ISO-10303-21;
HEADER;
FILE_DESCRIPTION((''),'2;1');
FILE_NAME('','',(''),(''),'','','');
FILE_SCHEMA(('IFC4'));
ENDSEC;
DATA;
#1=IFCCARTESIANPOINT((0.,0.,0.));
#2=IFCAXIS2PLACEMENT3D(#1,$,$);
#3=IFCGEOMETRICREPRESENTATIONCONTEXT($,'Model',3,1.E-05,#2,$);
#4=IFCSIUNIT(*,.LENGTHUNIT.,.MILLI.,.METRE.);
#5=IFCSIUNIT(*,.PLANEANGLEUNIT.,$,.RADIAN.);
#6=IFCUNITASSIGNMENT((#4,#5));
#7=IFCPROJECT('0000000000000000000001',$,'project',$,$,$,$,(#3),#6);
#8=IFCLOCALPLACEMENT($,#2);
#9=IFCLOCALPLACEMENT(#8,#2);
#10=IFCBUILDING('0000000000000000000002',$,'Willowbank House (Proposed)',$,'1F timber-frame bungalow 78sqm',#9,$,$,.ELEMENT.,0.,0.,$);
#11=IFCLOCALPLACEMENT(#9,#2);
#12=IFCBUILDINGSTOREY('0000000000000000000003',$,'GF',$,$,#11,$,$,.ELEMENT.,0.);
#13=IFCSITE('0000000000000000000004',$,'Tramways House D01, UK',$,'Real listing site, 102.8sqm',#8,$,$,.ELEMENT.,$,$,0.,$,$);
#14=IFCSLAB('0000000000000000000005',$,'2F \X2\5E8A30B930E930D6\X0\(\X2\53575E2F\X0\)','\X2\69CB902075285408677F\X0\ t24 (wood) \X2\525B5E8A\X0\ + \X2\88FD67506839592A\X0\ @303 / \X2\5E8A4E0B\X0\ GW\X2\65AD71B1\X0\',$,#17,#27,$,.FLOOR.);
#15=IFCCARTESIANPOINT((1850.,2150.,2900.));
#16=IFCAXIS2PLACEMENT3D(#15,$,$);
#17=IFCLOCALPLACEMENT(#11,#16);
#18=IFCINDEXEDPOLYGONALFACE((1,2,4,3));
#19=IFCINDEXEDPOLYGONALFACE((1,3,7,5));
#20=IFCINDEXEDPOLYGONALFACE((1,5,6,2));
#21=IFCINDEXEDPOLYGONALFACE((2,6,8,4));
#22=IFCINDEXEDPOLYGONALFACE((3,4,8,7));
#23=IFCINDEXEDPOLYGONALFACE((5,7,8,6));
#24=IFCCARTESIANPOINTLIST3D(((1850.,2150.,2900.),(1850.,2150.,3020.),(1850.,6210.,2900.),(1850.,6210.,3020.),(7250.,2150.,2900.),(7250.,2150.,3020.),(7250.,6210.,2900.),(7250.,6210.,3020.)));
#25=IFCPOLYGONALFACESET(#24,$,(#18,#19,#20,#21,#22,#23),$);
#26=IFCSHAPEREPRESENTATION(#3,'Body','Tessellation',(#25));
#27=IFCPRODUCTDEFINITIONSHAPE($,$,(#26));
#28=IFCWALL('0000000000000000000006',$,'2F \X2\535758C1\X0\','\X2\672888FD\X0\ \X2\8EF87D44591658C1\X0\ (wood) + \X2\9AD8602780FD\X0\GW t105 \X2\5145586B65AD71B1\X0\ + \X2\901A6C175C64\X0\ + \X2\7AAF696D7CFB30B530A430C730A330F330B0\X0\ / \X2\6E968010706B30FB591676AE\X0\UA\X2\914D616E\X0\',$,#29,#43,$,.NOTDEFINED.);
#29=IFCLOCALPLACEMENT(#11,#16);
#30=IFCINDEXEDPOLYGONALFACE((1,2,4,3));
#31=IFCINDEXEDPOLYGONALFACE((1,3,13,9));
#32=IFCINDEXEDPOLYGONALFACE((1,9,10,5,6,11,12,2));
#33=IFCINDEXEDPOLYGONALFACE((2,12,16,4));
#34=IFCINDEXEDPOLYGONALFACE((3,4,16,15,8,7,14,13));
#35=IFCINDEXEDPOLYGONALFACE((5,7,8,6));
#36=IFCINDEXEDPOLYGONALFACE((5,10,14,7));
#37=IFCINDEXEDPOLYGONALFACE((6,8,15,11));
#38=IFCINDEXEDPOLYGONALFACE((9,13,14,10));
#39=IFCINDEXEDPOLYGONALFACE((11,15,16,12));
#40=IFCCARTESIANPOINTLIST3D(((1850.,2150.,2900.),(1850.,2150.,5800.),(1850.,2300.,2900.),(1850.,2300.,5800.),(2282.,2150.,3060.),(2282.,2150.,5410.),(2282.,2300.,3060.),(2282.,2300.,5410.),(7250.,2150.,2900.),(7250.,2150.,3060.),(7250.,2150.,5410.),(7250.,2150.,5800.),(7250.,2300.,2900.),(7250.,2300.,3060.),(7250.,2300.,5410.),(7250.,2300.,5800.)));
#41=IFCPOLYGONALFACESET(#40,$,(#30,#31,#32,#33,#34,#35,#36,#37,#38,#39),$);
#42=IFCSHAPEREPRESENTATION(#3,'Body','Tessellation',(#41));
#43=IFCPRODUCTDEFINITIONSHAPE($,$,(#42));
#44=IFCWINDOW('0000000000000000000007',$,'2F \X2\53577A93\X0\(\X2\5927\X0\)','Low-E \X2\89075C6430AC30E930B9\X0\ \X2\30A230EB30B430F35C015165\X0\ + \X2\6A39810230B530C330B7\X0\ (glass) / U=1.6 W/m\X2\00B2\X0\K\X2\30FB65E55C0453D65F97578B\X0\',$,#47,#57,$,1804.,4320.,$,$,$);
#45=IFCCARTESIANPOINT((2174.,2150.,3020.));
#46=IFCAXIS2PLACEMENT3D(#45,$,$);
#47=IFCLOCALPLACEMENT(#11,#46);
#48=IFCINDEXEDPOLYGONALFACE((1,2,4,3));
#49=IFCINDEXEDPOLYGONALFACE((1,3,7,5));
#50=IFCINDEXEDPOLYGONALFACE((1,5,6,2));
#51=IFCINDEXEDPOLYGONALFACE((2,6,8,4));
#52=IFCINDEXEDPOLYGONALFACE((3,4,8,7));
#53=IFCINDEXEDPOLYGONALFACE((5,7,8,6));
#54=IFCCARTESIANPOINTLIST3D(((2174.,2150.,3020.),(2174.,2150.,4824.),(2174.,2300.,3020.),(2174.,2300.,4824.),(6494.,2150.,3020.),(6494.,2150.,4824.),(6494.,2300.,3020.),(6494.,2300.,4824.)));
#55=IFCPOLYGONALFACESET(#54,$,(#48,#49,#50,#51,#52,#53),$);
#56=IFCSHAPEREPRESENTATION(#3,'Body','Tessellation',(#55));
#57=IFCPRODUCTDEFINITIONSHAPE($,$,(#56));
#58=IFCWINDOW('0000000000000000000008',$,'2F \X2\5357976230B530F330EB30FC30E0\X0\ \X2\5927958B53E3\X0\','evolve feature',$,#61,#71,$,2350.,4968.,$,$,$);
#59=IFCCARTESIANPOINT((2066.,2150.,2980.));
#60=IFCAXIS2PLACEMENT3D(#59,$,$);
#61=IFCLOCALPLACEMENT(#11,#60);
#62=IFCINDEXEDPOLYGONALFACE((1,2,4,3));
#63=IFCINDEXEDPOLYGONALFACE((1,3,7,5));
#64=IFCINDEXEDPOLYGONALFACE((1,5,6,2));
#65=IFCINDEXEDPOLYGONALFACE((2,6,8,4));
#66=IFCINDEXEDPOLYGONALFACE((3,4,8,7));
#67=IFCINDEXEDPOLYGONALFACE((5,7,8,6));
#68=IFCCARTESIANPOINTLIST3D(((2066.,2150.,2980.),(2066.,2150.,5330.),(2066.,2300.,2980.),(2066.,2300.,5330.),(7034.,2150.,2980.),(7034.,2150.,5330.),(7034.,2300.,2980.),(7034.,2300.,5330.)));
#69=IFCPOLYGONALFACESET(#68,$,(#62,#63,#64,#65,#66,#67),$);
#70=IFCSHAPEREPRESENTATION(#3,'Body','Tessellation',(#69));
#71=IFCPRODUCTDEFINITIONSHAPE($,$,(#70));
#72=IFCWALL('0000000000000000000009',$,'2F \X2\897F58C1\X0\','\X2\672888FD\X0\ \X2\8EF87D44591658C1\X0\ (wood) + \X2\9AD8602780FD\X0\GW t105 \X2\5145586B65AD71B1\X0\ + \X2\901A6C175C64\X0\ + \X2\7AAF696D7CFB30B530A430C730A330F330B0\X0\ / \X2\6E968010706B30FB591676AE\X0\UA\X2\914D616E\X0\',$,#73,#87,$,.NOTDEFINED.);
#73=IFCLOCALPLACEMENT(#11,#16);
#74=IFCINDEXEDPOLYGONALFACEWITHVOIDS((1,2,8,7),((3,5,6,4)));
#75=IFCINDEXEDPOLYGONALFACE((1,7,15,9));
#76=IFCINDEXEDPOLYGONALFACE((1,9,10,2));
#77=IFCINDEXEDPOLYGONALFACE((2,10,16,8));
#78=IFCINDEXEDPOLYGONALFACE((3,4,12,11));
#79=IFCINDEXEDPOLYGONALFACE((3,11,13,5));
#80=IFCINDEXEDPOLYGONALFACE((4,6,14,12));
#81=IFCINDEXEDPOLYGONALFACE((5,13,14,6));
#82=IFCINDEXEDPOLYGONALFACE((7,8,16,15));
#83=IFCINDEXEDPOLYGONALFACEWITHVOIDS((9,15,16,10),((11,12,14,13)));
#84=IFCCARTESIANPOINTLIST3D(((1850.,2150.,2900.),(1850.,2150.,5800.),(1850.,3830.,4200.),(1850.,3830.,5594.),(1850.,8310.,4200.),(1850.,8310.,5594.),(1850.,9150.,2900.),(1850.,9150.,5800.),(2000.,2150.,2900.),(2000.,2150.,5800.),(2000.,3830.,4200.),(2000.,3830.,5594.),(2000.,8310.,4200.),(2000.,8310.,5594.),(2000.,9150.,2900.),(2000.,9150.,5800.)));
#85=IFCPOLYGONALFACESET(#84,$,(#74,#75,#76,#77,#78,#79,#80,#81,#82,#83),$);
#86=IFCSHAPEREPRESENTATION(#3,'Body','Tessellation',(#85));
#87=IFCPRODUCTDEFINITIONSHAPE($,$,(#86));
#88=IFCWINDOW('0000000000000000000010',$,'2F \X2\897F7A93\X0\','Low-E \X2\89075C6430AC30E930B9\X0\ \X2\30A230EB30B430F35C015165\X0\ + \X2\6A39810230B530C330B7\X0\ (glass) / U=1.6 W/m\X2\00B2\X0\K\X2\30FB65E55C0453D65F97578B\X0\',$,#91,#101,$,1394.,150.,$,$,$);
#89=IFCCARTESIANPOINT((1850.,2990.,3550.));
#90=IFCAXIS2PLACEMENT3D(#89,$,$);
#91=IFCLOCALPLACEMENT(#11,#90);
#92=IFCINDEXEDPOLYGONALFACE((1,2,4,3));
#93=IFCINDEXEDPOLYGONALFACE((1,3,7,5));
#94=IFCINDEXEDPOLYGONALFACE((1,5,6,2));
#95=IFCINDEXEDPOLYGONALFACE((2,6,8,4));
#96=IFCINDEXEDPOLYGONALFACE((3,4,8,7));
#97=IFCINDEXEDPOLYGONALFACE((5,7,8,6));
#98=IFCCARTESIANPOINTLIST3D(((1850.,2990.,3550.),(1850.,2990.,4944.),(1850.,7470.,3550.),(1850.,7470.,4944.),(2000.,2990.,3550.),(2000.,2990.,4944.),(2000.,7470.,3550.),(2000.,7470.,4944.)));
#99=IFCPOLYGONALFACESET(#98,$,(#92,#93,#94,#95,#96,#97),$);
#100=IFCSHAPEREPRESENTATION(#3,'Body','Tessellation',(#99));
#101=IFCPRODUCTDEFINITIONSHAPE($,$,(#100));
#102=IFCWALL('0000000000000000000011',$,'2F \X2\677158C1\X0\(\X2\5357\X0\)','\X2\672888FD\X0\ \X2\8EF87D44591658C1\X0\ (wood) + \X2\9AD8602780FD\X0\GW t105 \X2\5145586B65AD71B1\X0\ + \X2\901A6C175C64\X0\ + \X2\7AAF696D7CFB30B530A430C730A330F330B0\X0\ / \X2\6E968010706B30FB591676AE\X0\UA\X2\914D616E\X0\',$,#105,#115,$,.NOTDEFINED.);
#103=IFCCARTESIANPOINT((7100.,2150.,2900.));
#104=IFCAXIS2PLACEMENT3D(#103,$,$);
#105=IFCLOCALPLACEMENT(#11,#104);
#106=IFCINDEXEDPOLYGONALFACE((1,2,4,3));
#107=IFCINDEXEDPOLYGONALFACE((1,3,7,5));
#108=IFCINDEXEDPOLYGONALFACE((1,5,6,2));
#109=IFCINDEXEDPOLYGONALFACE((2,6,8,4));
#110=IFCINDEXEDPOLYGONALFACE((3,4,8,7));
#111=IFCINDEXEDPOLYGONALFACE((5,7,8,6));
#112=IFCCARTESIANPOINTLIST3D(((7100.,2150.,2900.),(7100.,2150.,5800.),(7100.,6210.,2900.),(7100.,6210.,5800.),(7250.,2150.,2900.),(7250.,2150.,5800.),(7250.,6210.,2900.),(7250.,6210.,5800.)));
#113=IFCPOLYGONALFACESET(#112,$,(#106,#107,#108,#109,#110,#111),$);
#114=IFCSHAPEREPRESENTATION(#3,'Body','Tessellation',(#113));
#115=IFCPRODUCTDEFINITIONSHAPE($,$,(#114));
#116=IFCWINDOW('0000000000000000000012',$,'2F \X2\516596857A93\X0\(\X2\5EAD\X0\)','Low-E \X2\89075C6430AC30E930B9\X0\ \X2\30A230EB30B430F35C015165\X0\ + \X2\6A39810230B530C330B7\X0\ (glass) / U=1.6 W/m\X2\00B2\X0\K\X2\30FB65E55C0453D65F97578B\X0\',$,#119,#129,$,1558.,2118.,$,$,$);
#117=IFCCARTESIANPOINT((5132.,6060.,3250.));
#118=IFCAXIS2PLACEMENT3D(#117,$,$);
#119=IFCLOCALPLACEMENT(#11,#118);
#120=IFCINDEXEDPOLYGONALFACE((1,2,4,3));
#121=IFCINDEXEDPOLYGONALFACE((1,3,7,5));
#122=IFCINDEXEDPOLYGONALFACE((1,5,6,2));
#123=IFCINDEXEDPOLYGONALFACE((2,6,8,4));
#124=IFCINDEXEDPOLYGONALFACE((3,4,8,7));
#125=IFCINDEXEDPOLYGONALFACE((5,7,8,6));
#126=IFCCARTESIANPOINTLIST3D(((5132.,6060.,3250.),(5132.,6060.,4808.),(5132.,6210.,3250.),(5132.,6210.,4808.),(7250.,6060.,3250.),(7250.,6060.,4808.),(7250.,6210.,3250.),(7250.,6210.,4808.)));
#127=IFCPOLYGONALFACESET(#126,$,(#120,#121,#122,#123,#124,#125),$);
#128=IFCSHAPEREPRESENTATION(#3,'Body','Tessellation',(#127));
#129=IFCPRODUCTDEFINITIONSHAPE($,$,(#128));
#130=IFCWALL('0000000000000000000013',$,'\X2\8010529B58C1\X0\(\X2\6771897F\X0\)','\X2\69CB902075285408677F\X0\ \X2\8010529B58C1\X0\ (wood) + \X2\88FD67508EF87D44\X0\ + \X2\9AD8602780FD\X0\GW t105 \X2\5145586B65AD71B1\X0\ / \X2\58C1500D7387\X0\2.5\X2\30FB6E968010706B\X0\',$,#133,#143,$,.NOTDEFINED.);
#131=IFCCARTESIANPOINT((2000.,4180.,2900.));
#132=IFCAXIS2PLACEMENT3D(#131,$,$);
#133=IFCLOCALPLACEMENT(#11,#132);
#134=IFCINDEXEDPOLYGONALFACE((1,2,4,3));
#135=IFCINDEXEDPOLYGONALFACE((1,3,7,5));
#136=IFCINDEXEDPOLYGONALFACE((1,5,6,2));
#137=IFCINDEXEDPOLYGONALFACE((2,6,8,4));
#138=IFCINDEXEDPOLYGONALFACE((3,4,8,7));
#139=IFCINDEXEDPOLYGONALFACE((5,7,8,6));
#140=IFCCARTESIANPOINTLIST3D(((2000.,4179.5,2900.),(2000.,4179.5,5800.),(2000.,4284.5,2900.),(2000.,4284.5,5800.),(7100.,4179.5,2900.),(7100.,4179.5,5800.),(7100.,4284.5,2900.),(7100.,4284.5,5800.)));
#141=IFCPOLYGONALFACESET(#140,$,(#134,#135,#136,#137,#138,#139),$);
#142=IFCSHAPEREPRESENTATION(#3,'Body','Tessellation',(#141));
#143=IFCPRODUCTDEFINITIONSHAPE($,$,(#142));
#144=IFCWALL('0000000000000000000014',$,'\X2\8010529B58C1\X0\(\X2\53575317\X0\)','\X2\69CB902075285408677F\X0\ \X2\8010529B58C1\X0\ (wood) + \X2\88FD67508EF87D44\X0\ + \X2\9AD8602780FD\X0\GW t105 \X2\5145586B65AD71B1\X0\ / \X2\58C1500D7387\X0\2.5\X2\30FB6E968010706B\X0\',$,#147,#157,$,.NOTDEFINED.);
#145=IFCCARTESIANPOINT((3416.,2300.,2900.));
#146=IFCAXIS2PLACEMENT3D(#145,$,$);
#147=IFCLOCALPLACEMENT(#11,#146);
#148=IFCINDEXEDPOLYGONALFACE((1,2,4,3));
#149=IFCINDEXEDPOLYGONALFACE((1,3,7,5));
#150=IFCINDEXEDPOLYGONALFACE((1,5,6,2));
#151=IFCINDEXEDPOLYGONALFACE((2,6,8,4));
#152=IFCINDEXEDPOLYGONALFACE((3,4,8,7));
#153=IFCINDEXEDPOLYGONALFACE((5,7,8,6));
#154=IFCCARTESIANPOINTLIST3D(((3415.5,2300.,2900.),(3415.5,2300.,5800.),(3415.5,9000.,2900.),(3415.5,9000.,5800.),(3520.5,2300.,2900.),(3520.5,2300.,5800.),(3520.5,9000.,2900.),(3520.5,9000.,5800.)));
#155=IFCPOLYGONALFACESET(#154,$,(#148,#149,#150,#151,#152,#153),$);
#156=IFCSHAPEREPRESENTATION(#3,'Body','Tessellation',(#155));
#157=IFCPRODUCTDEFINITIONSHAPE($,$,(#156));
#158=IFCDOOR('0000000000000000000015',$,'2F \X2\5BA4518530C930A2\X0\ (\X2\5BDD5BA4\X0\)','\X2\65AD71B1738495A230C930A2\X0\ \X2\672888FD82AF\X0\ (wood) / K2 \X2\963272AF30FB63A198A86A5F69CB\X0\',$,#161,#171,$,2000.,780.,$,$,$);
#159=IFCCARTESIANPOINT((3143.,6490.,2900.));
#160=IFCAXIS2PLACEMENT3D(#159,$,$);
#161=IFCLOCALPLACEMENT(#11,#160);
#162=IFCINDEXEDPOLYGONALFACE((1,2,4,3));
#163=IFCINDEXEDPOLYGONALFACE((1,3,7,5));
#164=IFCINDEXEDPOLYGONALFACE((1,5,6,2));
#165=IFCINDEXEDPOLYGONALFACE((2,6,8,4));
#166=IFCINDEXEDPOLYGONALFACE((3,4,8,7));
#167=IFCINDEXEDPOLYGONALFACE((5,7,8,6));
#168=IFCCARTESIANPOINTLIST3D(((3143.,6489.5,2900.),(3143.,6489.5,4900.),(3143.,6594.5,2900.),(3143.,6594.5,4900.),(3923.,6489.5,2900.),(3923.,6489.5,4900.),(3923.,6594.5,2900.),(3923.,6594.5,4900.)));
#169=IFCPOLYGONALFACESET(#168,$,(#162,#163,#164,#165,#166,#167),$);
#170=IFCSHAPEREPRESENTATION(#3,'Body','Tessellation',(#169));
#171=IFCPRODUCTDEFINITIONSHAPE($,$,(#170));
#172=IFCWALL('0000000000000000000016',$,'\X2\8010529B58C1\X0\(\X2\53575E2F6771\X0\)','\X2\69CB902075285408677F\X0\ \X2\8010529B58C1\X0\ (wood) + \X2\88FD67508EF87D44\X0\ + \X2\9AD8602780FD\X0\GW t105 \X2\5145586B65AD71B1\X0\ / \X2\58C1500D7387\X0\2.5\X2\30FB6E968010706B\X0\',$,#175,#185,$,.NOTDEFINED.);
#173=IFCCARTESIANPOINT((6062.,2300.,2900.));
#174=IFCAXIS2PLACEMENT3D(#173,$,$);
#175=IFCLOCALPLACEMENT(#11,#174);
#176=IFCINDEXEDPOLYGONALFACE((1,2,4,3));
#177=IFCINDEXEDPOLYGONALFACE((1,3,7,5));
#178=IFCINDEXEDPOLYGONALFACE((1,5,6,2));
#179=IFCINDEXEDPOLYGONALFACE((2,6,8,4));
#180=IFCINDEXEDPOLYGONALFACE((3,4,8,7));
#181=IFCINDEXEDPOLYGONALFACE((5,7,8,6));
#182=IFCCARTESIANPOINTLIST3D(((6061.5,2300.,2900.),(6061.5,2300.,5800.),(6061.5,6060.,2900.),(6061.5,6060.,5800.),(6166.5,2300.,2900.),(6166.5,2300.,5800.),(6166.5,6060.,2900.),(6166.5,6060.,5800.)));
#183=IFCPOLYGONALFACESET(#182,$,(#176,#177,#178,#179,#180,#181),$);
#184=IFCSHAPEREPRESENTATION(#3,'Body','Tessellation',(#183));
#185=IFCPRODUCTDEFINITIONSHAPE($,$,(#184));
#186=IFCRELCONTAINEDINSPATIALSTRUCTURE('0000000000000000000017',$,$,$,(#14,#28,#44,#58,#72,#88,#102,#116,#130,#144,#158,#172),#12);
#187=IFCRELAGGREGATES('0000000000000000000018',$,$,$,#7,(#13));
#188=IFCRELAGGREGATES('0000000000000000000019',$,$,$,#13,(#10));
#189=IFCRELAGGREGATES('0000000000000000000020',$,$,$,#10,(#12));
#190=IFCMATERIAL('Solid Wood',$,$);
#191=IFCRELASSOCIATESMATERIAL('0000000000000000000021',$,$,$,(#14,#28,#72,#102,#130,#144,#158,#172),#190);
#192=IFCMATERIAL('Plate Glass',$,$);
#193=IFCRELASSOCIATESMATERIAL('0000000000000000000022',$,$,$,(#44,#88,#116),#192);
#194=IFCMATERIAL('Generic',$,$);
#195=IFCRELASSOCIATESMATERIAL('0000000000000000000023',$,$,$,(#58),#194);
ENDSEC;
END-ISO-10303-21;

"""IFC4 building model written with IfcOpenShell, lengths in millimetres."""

from ifc_helpers import new_model, si_unit, frame, frame_2d, origin, place, context, project, spatial, rectangle, extrude, material, element, fill, save


model = new_model("IFC4")

# Units and contexts
model_context = context("Model", 3, precision=1e-05, world=origin())
ifc_project = project(units=[si_unit("LENGTHUNIT", "METRE", prefix="MILLI"), si_unit("PLANEANGLEUNIT", "RADIAN")], contexts=[model_context])

# Site, building, storey
site_placement = place(None, origin())
site = spatial("IfcSite", under=ifc_project, at=site_placement, Name="Tramways House D01, UK", ObjectType="Real listing site, 102.8sqm", CompositionType="ELEMENT", RefElevation=0.0)
building_placement = place(site_placement, origin())
building = spatial("IfcBuilding", under=site, at=building_placement, Name="Willowbank House (Proposed)", ObjectType="1F timber-frame bungalow 78sqm", CompositionType="ELEMENT", ElevationOfRefHeight=0.0, ElevationOfTerrain=0.0)
storey_placement = place(building_placement, origin())
storey = spatial("IfcBuildingStorey", under=building, at=storey_placement, Name="GF", CompositionType="ELEMENT", Elevation=0.0)

# Slab
ifc_material_1 = material(Name="Solid Wood")
slab_placement = place(storey_placement, frame((1850.0, 2150.0, 2900.0)))
element("IfcSlab", 1, at=slab_placement, inside=storey, material=ifc_material_1, Name="2F 床スラブ(南帯)", Description="構造用合板 t24 (wood) 剛床 + 製材根太 @303 / 床下 GW断熱", PredefinedType="FLOOR", context=model_context, shape_type="SweptSolid", body=[
    extrude(rectangle(XDim=5400.0, YDim=4060.0, at=frame_2d((2700.0, 2030.0))), frame((1850.0, 2150.0, 2900.0)), (0.0, 0.0, 1.0), 120.0),
])

# Wall, openings, windows
wall_1_placement = place(storey_placement, frame((1850.0, 2150.0, 2900.0)))
wall_1 = element("IfcWall", 2, at=wall_1_placement, inside=storey, material=ifc_material_1, Name="2F 南壁", Description="木製 軸組外壁 (wood) + 高性能GW t105 充填断熱 + 通気層 + 窯業系サイディング / 準耐火・外皮UA配慮", PredefinedType="NOTDEFINED", context=model_context, shape_type="SweptSolid", body=[
    extrude(rectangle(XDim=5400.0, YDim=150.0, at=frame_2d((2700.0, 75.0))), frame((1850.0, 2150.0, 2900.0)), (0.0, 0.0, 1.0), 2900.0),
])
opening_1_placement = place(storey_placement, frame((2174.0, 2150.0, 3020.0)))
opening_1 = element("IfcOpeningElement", 3, at=opening_1_placement, cuts=wall_1, PredefinedType="NOTDEFINED", context=model_context, shape_type="SweptSolid", body=[
    extrude(rectangle(XDim=4320.0, YDim=150.0, at=frame_2d((2160.0, 75.0))), frame((2174.0, 2150.0, 3020.0)), (0.0, 0.0, 1.0), 1804.0),
])
opening_2_placement = place(storey_placement, frame((2066.0, 2150.0, 2980.0)))
opening_2 = element("IfcOpeningElement", 4, at=opening_2_placement, cuts=wall_1, PredefinedType="NOTDEFINED", context=model_context, shape_type="SweptSolid", body=[
    extrude(rectangle(XDim=4968.0, YDim=150.0, at=frame_2d((2484.0, 75.0))), frame((2066.0, 2150.0, 2980.0)), (0.0, 0.0, 1.0), 2350.0),
])
ifc_material_2 = material(Name="Plate Glass")
window_1_placement = place(storey_placement, frame((2174.0, 2150.0, 3020.0)))
window_1 = element("IfcWindow", 5, at=window_1_placement, inside=storey, material=ifc_material_2, Name="2F 南窓(大)", Description="Low-E 複層ガラス アルゴン封入 + 樹脂サッシ (glass) / U=1.6 W/m²K・日射取得型", OverallHeight=1804.0, OverallWidth=4320.0, context=model_context, shape_type="SweptSolid", body=[
    extrude(rectangle(XDim=4320.0, YDim=150.0, at=frame_2d((2160.0, 75.0))), frame((2174.0, 2150.0, 3020.0)), (0.0, 0.0, 1.0), 1804.0),
])
fill(opening_1, window_1)
ifc_material_3 = material(Name="Generic")
window_2_placement = place(storey_placement, frame((2066.0, 2150.0, 2980.0)))
window_2 = element("IfcWindow", 6, at=window_2_placement, inside=storey, material=ifc_material_3, Name="2F 南面サンルーム 大開口", Description="evolve feature", OverallHeight=2350.0, OverallWidth=4968.0, context=model_context, shape_type="SweptSolid", body=[
    extrude(rectangle(XDim=4968.0, YDim=150.0, at=frame_2d((2484.0, 75.0))), frame((2066.0, 2150.0, 2980.0)), (0.0, 0.0, 1.0), 2350.0),
])
fill(opening_2, window_2)

# Walls, openings, windows
wall_2_placement = place(storey_placement, frame((1850.0, 2150.0, 2900.0)))
wall_2 = element("IfcWall", 7, at=wall_2_placement, inside=storey, material=ifc_material_1, Name="2F 西壁", Description="木製 軸組外壁 (wood) + 高性能GW t105 充填断熱 + 通気層 + 窯業系サイディング / 準耐火・外皮UA配慮", PredefinedType="NOTDEFINED", context=model_context, shape_type="SweptSolid", body=[
    extrude(rectangle(XDim=150.0, YDim=7000.0, at=frame_2d((75.0, 3500.0))), frame((1850.0, 2150.0, 2900.0)), (0.0, 0.0, 1.0), 2900.0),
])
opening_3_placement = place(storey_placement, frame((1850.0, 2990.0, 3550.0)))
opening_3 = element("IfcOpeningElement", 8, at=opening_3_placement, cuts=wall_2, PredefinedType="NOTDEFINED", context=model_context, shape_type="SweptSolid", body=[
    extrude(rectangle(XDim=150.0, YDim=4480.0, at=frame_2d((75.0, 2240.0))), frame((1850.0, 2990.0, 3550.0)), (0.0, 0.0, 1.0), 1394.0),
])
window_3_placement = place(storey_placement, frame((1850.0, 2990.0, 3550.0)))
window_3 = element("IfcWindow", 9, at=window_3_placement, inside=storey, material=ifc_material_2, Name="2F 西窓", Description="Low-E 複層ガラス アルゴン封入 + 樹脂サッシ (glass) / U=1.6 W/m²K・日射取得型", OverallHeight=1394.0, OverallWidth=150.0, context=model_context, shape_type="SweptSolid", body=[
    extrude(rectangle(XDim=150.0, YDim=4480.0, at=frame_2d((75.0, 2240.0))), frame((1850.0, 2990.0, 3550.0)), (0.0, 0.0, 1.0), 1394.0),
])
fill(opening_3, window_3)
wall_3_placement = place(storey_placement, frame((7100.0, 2150.0, 2900.0)))
wall_3 = element("IfcWall", 10, at=wall_3_placement, inside=storey, material=ifc_material_1, Name="2F 東壁(南)", Description="木製 軸組外壁 (wood) + 高性能GW t105 充填断熱 + 通気層 + 窯業系サイディング / 準耐火・外皮UA配慮", PredefinedType="NOTDEFINED", context=model_context, shape_type="SweptSolid", body=[
    extrude(rectangle(XDim=150.0, YDim=4060.0, at=frame_2d((75.0, 2030.0))), frame((7100.0, 2150.0, 2900.0)), (0.0, 0.0, 1.0), 2900.0),
])
opening_4_placement = place(storey_placement, frame((5132.0, 6060.0, 3250.0)))
opening_4 = element("IfcOpeningElement", 11, at=opening_4_placement, cuts=wall_3, PredefinedType="NOTDEFINED", context=model_context, shape_type="SweptSolid", body=[
    extrude(rectangle(XDim=2118.0, YDim=150.0, at=frame_2d((1059.0, 75.0))), frame((5132.0, 6060.0, 3250.0)), (0.0, 0.0, 1.0), 1558.0),
])
window_4_placement = place(storey_placement, frame((5132.0, 6060.0, 3250.0)))
window_4 = element("IfcWindow", 12, at=window_4_placement, inside=storey, material=ifc_material_2, Name="2F 入隅窓(庭)", Description="Low-E 複層ガラス アルゴン封入 + 樹脂サッシ (glass) / U=1.6 W/m²K・日射取得型", OverallHeight=1558.0, OverallWidth=2118.0, context=model_context, shape_type="SweptSolid", body=[
    extrude(rectangle(XDim=2118.0, YDim=150.0, at=frame_2d((1059.0, 75.0))), frame((5132.0, 6060.0, 3250.0)), (0.0, 0.0, 1.0), 1558.0),
])
fill(opening_4, window_4)

# Wall
wall_4_placement = place(storey_placement, frame((2000.0, 4180.0, 2900.0)))
element("IfcWall", 13, at=wall_4_placement, inside=storey, material=ifc_material_1, Name="耐力壁(東西)", Description="構造用合板 耐力壁 (wood) + 製材軸組 + 高性能GW t105 充填断熱 / 壁倍率2.5・準耐火", PredefinedType="NOTDEFINED", context=model_context, shape_type="SweptSolid", body=[
    extrude(rectangle(XDim=5100.0, YDim=105.0, at=frame_2d((2550.0, 52.0))), frame((2000.0, 4180.0, 2900.0)), (0.0, 0.0, 1.0), 2900.0),
])

# Wall, opening, door
wall_5_placement = place(storey_placement, frame((3416.0, 2300.0, 2900.0)))
wall_5 = element("IfcWall", 14, at=wall_5_placement, inside=storey, material=ifc_material_1, Name="耐力壁(南北)", Description="構造用合板 耐力壁 (wood) + 製材軸組 + 高性能GW t105 充填断熱 / 壁倍率2.5・準耐火", PredefinedType="NOTDEFINED", context=model_context, shape_type="SweptSolid", body=[
    extrude(rectangle(XDim=105.0, YDim=6700.0, at=frame_2d((52.0, 3350.0))), frame((3416.0, 2300.0, 2900.0)), (0.0, 0.0, 1.0), 2900.0),
])
opening_5_placement = place(storey_placement, frame((3143.0, 6490.0, 2900.0)))
opening_5 = element("IfcOpeningElement", 15, at=opening_5_placement, cuts=wall_5, PredefinedType="NOTDEFINED", context=model_context, shape_type="SweptSolid", body=[
    extrude(rectangle(XDim=780.0, YDim=105.0, at=frame_2d((390.0, 52.0))), frame((3143.0, 6490.0, 2900.0)), (0.0, 0.0, 1.0), 2000.0),
])
door_placement = place(storey_placement, frame((3143.0, 6490.0, 2900.0)))
door = element("IfcDoor", 16, at=door_placement, inside=storey, material=ifc_material_1, Name="2F 室内ドア (寝室)", Description="断熱玄関ドア 木製芯 (wood) / K2 防犯・採風機構", OverallHeight=2000.0, OverallWidth=780.0, context=model_context, shape_type="SweptSolid", body=[
    extrude(rectangle(XDim=780.0, YDim=105.0, at=frame_2d((390.0, 52.0))), frame((3143.0, 6490.0, 2900.0)), (0.0, 0.0, 1.0), 2000.0),
])
fill(opening_5, door)

# Wall
wall_6_placement = place(storey_placement, frame((6062.0, 2300.0, 2900.0)))
element("IfcWall", 17, at=wall_6_placement, inside=storey, material=ifc_material_1, Name="耐力壁(南帯東)", Description="構造用合板 耐力壁 (wood) + 製材軸組 + 高性能GW t105 充填断熱 / 壁倍率2.5・準耐火", PredefinedType="NOTDEFINED", context=model_context, shape_type="SweptSolid", body=[
    extrude(rectangle(XDim=105.0, YDim=3760.0, at=frame_2d((52.0, 1880.0))), frame((6062.0, 2300.0, 2900.0)), (0.0, 0.0, 1.0), 2900.0),
])

save(model, "model.ifc")
